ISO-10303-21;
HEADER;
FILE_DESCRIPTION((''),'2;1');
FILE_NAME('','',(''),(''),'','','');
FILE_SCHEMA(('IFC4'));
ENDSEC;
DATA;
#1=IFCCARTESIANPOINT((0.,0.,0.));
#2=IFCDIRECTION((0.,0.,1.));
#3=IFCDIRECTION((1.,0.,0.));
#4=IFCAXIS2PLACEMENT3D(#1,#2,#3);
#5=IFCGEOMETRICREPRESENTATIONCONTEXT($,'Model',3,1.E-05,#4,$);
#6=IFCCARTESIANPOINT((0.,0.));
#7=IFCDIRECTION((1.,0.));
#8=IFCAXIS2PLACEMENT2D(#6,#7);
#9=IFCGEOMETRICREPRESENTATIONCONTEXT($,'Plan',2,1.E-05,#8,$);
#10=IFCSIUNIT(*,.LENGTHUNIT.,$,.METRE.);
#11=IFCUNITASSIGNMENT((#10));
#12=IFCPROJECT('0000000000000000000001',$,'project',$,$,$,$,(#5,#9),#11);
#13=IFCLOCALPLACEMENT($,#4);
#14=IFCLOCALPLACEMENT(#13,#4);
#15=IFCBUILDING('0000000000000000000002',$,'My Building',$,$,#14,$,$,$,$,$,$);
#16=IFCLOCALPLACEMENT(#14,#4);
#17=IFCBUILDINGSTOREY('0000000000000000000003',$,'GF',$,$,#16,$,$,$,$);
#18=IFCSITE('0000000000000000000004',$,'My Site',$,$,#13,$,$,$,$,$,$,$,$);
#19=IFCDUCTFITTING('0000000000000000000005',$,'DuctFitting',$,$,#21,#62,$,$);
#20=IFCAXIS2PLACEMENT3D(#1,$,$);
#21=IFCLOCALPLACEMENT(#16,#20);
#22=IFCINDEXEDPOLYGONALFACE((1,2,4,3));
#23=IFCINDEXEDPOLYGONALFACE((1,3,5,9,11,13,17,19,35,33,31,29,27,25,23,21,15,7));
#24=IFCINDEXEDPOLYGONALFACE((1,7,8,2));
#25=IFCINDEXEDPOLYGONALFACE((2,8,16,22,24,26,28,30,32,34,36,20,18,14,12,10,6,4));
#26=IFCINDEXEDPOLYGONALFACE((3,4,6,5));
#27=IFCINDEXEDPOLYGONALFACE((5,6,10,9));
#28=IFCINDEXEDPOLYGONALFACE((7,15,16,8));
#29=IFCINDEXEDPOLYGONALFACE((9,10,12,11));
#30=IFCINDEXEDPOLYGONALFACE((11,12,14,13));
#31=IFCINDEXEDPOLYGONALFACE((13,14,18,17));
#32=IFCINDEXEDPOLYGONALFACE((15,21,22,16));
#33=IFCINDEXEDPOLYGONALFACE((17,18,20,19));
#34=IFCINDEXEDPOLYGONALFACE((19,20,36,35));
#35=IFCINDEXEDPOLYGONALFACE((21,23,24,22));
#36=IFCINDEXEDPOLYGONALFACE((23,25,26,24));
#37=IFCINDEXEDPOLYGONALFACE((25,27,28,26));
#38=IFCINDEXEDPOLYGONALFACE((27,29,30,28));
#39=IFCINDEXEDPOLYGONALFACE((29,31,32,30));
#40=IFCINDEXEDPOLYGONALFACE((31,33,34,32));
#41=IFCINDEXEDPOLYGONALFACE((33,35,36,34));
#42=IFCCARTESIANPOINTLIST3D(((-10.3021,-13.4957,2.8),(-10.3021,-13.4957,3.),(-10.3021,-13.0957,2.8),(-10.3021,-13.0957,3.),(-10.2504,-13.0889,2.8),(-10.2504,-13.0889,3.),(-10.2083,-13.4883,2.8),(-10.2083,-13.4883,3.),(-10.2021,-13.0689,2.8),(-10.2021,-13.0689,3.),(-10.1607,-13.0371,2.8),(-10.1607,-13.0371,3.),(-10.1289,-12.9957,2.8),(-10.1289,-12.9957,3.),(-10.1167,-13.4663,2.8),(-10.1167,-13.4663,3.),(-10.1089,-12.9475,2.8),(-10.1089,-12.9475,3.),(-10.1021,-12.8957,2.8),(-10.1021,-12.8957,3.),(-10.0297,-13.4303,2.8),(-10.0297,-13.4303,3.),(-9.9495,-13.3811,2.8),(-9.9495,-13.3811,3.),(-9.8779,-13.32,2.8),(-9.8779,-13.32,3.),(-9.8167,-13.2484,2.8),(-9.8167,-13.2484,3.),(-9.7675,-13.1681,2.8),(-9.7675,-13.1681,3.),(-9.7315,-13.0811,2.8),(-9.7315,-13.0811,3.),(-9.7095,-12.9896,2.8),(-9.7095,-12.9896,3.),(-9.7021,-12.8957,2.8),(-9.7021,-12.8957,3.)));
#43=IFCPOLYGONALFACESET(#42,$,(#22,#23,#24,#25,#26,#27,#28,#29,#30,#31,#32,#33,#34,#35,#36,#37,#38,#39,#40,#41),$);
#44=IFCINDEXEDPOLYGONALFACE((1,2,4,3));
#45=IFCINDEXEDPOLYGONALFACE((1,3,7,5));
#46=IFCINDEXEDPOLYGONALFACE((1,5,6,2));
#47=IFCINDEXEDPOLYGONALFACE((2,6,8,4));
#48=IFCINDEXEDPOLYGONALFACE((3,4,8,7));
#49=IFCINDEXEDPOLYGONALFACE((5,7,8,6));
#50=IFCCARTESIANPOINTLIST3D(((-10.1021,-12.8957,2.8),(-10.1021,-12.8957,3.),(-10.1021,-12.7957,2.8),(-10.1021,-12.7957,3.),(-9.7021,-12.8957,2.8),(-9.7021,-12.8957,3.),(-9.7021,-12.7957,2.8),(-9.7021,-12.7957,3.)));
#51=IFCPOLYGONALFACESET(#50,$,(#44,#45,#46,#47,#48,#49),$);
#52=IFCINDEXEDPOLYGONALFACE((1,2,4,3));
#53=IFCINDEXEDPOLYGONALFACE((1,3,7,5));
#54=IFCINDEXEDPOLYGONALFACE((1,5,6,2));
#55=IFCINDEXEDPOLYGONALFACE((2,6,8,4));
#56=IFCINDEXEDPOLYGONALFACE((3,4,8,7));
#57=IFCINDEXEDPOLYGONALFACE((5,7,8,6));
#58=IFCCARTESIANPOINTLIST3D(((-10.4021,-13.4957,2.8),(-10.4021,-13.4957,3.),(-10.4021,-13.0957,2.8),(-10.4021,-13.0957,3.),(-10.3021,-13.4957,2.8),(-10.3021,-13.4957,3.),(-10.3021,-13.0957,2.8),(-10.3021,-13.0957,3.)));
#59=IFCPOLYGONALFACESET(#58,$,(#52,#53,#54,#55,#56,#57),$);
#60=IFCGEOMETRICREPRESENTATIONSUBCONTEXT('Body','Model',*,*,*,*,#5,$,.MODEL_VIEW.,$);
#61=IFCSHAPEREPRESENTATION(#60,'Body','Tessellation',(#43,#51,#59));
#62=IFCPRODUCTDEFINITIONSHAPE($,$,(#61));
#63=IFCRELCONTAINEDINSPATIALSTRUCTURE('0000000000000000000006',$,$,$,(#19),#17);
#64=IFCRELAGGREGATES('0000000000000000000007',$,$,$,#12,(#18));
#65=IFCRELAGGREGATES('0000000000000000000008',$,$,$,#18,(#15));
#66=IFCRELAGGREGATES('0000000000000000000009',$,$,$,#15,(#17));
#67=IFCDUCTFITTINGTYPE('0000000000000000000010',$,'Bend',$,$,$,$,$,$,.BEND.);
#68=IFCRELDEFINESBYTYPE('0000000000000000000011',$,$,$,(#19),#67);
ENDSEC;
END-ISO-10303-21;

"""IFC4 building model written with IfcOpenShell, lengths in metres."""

from ifc_helpers import new_model, si_unit, frame, origin_with_axes, origin_2d_with_axis, place, context, subcontext, project, spatial, line, arc, indexed_curve, rectangle, outline, extrude, source, transform, mapped, type_object, type_shapes, element, save


model = new_model("IFC4")

# Units and contexts
model_context = context("Model", 3, precision=1e-05, world=origin_with_axes())
plan_context = context("Plan", 2, precision=1e-05, world=origin_2d_with_axis())
body_context_1 = subcontext(model_context, "Body", "Model", "MODEL_VIEW")
ifc_project = project(units=[si_unit("LENGTHUNIT", "METRE")], contexts=[model_context, plan_context])

# Site, building, storey
site_placement = place(None, origin_with_axes())
site = spatial("IfcSite", under=ifc_project, at=site_placement, Name="My Site")
building_placement = place(site_placement, origin_with_axes())
building = spatial("IfcBuilding", under=site, at=building_placement, Name="My Building")
storey_placement = place(building_placement, origin_with_axes())
storey = spatial("IfcBuildingStorey", under=building, at=storey_placement, Name="GF")

# Duct fitting
duct_fitting_type = type_object("IfcDuctFittingType", Name="Bend", PredefinedType="BEND")
shared_shape_1 = source(origin_with_axes(), body_context_1, "Body", "SweptSolid", [
    extrude(outline(indexed_curve([(-0.2, 0.0), (-0.2586, 0.1414), (-0.4, 0.2), (-0.4, 0.6), (0.0243, 0.4243), (0.2, 0.0)], segments=[arc(1, 2, 3), line(3, 4), arc(4, 5, 6), line(6, 1)])), frame((0.0, -0.1, 0.1), z_axis=(0.0, -1.0, 0.0), x_axis=(1.0, 0.0, 0.0)), (0.0, 0.0, -1.0), 0.2),
    extrude(rectangle(XDim=0.4, YDim=0.2), origin_with_axes(), (0.0, 0.0, 1.0), 0.1),
    extrude(rectangle(XDim=0.4, YDim=0.2), frame((-0.4, 0.0, 0.5), z_axis=(-1.0, 0.0, 0.0), x_axis=(0.0, 0.0, -1.0)), (0.0, 0.0, 1.0), 0.1),
])
type_shapes(duct_fitting_type, [shared_shape_1])
duct_fitting_placement = place(storey_placement, frame((-9.9021, -12.7957, 2.9), z_axis=(0.0, -1.0, 0.0), x_axis=(1.0, 0.0, 0.0)))
element("IfcDuctFitting", 1, at=duct_fitting_placement, inside=storey, type_object=duct_fitting_type, Name="DuctFitting", context=body_context_1, shape_type="MappedRepresentation", body=[
    mapped(shared_shape_1, transform((0.0, 0.0, 0.0), x_axis=(1.0, 0.0, 0.0), y_axis=(0.0, 1.0, 0.0), z_axis=(0.0, 0.0, 1.0), scale=1.0)),
])

save(model, "model.ifc")
